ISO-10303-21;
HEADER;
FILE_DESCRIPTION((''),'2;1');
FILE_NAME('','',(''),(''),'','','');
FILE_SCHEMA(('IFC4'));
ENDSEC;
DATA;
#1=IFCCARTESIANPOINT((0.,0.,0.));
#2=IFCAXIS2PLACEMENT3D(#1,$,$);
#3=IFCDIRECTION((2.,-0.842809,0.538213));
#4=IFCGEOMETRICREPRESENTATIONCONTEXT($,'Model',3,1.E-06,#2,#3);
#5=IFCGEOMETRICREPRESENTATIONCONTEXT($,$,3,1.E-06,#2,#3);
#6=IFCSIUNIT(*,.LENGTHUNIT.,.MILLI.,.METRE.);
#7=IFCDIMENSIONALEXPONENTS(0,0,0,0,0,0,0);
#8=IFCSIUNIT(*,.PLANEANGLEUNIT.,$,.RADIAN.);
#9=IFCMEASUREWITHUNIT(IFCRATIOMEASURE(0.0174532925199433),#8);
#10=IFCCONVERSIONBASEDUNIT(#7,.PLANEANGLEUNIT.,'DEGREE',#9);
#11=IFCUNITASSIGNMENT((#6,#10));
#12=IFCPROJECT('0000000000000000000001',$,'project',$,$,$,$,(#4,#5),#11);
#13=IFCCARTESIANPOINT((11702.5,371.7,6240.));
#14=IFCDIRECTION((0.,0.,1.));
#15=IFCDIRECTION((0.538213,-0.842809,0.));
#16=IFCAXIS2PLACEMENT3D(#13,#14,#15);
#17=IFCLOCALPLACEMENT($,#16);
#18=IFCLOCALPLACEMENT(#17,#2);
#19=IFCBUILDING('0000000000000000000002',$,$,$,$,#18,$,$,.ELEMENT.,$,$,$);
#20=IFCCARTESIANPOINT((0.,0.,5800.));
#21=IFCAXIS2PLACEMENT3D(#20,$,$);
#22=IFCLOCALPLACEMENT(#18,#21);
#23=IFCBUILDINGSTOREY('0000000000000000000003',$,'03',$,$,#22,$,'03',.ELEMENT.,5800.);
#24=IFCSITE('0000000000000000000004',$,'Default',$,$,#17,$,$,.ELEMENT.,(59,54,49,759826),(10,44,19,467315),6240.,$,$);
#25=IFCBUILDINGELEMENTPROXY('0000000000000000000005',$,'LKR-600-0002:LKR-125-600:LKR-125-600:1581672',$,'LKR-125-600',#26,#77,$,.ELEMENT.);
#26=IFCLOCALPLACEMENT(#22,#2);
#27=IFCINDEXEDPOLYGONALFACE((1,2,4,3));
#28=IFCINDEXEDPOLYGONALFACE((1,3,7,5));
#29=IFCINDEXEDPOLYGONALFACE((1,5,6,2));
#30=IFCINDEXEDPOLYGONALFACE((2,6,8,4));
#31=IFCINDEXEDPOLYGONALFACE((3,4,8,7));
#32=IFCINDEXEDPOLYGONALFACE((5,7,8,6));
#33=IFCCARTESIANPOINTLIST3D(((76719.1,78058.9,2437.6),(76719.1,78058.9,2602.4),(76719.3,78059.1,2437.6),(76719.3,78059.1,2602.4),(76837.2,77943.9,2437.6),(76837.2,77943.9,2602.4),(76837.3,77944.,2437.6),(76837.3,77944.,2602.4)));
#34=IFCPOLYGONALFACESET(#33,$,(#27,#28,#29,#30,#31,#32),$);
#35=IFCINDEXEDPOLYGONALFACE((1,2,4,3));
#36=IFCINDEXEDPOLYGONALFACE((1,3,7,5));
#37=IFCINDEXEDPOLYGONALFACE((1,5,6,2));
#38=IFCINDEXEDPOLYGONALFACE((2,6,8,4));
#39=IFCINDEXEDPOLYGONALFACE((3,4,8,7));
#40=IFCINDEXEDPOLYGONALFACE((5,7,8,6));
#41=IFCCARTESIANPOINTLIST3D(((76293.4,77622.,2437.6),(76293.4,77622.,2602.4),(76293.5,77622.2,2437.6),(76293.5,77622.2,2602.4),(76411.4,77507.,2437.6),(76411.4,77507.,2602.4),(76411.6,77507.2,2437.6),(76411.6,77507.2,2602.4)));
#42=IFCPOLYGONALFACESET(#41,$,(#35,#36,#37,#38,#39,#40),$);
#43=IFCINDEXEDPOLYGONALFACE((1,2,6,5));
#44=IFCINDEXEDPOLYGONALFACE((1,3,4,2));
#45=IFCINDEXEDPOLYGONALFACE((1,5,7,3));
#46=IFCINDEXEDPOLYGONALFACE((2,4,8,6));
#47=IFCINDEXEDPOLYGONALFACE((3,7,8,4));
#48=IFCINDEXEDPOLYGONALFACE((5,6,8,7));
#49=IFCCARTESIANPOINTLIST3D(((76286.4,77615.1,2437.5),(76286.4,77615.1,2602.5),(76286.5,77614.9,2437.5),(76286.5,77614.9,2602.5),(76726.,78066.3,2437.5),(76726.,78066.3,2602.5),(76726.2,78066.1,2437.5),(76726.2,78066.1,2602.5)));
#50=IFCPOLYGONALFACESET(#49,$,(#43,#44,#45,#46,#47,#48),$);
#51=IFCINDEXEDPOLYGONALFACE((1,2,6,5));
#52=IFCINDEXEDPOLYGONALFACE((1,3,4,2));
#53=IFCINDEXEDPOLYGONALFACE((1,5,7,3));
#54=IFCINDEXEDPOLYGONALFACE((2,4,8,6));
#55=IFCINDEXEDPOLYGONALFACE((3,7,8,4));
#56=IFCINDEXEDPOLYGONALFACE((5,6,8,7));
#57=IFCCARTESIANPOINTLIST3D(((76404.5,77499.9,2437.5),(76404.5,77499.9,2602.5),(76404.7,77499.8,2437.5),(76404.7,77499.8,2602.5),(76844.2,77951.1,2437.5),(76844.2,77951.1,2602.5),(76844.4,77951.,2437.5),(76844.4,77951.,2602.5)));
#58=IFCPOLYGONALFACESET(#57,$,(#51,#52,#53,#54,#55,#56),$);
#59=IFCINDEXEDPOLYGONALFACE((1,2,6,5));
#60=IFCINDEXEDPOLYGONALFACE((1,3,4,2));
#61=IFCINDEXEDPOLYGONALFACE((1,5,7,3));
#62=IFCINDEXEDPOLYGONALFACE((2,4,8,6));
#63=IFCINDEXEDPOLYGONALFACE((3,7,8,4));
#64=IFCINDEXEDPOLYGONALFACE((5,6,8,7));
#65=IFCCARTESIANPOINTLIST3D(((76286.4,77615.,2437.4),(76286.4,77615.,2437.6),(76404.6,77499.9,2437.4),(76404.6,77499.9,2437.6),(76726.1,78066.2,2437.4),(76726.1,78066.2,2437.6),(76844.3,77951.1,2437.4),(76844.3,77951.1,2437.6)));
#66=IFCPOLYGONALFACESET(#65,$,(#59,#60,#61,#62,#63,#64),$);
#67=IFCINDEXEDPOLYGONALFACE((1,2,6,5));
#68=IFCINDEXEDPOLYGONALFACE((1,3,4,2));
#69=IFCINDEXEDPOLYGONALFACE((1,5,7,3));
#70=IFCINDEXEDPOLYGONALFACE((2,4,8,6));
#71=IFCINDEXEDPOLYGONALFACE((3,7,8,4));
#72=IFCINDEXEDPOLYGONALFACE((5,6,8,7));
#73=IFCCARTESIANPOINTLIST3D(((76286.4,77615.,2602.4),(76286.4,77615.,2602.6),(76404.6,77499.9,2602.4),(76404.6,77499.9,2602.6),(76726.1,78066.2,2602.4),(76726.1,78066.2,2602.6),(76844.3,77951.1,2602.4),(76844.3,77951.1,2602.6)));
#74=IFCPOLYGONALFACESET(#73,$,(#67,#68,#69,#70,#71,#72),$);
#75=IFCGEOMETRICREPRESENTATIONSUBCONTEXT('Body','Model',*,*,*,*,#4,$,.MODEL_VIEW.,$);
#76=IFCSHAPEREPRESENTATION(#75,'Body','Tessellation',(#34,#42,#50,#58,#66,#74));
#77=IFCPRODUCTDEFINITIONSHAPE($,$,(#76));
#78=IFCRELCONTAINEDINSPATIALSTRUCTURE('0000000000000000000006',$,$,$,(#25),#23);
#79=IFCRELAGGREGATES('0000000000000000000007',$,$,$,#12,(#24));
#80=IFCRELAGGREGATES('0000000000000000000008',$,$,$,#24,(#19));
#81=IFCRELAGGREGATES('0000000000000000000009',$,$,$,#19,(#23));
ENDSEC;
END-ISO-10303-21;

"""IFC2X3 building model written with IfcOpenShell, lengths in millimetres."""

from ifc_helpers import new_model, entity, si_unit, converted_unit, direction, frame, frame_2d, origin, place, context, subcontext, project, spatial, rectangle, extrude, source, transform, mapped, element, save


model = new_model("IFC2X3")

# Units and contexts
model_context = context("Model", 3, precision=1e-06, world=origin(), true_north=direction((2.0, -0.842809, 0.538213)))
context_of_model = context(None, 3, precision=1e-06, world=origin(), true_north=direction((2.0, -0.842809, 0.538213)))
body_context = subcontext(model_context, "Body", "Model", "MODEL_VIEW")
ifc_project = project(units=[si_unit("LENGTHUNIT", "METRE", prefix="MILLI"), converted_unit("PLANEANGLEUNIT", "DEGREE", entity("IfcRatioMeasure", 0.0174532925199433), si_unit("PLANEANGLEUNIT", "RADIAN"), dimensions=[0, 0, 0, 0, 0, 0, 0])], contexts=[model_context, context_of_model])

# Site, building, storey
site_placement = place(None, frame((11702.5, 371.7, 6240.0), z_axis=(0.0, 0.0, 1.0), x_axis=(0.538213, -0.842809, 0.0)))
site = spatial("IfcSite", under=ifc_project, at=site_placement, Name="Default", CompositionType="ELEMENT", RefLatitude=(59, 54, 49, 759826), RefLongitude=(10, 44, 19, 467315), RefElevation=6240.0)
building_placement = place(site_placement, origin())
building = spatial("IfcBuilding", under=site, at=building_placement, CompositionType="ELEMENT")
storey_placement = place(building_placement, frame((0.0, 0.0, 5800.0)))
storey = spatial("IfcBuildingStorey", under=building, at=storey_placement, Name="03", LongName="03", CompositionType="ELEMENT", Elevation=5800.0)

# Building element proxy
shared_shape_1 = source(origin(), body_context, "Body", "SweptSolid", [
    extrude(rectangle(XDim=0.2, YDim=164.8, at=frame_2d((0.0, 0.0), x_axis=(1.0, 0.0))), frame((305.0, 0.0, -82.4)), (0.0, 0.0, 1.0), 164.8),
    extrude(rectangle(XDim=0.2, YDim=164.8, at=frame_2d((0.0, 0.0), x_axis=(1.0, 0.0))), frame((-305.0, 0.0, -82.4)), (0.0, 0.0, 1.0), 164.8),
    extrude(rectangle(XDim=0.2, YDim=630.0, at=frame_2d((0.0, 0.0), x_axis=(1.0, 0.0))), frame((0.0, 82.5, -82.5), z_axis=(0.0, 0.0, 1.0), x_axis=(0.0, 1.0, 0.0)), (0.0, 0.0, 1.0), 165.0),
    extrude(rectangle(XDim=0.2, YDim=630.0, at=frame_2d((0.0, 0.0), x_axis=(1.0, 0.0))), frame((0.0, -82.5, -82.5), z_axis=(0.0, 0.0, 1.0), x_axis=(0.0, 1.0, 0.0)), (0.0, 0.0, 1.0), 165.0),
    extrude(rectangle(XDim=165.0, YDim=630.0, at=frame_2d((0.0, 0.0), x_axis=(1.0, 0.0))), frame((0.0, 0.0, -82.6), z_axis=(0.0, 0.0, 1.0), x_axis=(0.0, -1.0, 0.0)), (0.0, 0.0, 1.0), 0.2),
    extrude(rectangle(XDim=165.0, YDim=630.0, at=frame_2d((0.0, 0.0), x_axis=(1.0, 0.0))), frame((0.0, 0.0, 82.4), z_axis=(0.0, 0.0, 1.0), x_axis=(0.0, -1.0, 0.0)), (0.0, 0.0, 1.0), 0.2),
])
for number, where, z_axis, x_axis, name in (
    (1, (76565.4, 77783.0, 2520.0), (0.0, 0.0, 1.0), (0.697915, 0.71618, 0.0), "LKR-600-0002:LKR-125-600:LKR-125-600:1581672"),
):
    element("IfcBuildingElementProxy", number, at=place(storey_placement, frame(where, z_axis=z_axis, x_axis=x_axis)), inside=storey, Name=name, ObjectType="LKR-125-600", CompositionType="ELEMENT", context=body_context, shape_type="MappedRepresentation", body=[
        mapped(shared_shape_1, transform((0.0, 0.0, 0.0), scale=1.0)),
    ])

save(model, "model.ifc")
